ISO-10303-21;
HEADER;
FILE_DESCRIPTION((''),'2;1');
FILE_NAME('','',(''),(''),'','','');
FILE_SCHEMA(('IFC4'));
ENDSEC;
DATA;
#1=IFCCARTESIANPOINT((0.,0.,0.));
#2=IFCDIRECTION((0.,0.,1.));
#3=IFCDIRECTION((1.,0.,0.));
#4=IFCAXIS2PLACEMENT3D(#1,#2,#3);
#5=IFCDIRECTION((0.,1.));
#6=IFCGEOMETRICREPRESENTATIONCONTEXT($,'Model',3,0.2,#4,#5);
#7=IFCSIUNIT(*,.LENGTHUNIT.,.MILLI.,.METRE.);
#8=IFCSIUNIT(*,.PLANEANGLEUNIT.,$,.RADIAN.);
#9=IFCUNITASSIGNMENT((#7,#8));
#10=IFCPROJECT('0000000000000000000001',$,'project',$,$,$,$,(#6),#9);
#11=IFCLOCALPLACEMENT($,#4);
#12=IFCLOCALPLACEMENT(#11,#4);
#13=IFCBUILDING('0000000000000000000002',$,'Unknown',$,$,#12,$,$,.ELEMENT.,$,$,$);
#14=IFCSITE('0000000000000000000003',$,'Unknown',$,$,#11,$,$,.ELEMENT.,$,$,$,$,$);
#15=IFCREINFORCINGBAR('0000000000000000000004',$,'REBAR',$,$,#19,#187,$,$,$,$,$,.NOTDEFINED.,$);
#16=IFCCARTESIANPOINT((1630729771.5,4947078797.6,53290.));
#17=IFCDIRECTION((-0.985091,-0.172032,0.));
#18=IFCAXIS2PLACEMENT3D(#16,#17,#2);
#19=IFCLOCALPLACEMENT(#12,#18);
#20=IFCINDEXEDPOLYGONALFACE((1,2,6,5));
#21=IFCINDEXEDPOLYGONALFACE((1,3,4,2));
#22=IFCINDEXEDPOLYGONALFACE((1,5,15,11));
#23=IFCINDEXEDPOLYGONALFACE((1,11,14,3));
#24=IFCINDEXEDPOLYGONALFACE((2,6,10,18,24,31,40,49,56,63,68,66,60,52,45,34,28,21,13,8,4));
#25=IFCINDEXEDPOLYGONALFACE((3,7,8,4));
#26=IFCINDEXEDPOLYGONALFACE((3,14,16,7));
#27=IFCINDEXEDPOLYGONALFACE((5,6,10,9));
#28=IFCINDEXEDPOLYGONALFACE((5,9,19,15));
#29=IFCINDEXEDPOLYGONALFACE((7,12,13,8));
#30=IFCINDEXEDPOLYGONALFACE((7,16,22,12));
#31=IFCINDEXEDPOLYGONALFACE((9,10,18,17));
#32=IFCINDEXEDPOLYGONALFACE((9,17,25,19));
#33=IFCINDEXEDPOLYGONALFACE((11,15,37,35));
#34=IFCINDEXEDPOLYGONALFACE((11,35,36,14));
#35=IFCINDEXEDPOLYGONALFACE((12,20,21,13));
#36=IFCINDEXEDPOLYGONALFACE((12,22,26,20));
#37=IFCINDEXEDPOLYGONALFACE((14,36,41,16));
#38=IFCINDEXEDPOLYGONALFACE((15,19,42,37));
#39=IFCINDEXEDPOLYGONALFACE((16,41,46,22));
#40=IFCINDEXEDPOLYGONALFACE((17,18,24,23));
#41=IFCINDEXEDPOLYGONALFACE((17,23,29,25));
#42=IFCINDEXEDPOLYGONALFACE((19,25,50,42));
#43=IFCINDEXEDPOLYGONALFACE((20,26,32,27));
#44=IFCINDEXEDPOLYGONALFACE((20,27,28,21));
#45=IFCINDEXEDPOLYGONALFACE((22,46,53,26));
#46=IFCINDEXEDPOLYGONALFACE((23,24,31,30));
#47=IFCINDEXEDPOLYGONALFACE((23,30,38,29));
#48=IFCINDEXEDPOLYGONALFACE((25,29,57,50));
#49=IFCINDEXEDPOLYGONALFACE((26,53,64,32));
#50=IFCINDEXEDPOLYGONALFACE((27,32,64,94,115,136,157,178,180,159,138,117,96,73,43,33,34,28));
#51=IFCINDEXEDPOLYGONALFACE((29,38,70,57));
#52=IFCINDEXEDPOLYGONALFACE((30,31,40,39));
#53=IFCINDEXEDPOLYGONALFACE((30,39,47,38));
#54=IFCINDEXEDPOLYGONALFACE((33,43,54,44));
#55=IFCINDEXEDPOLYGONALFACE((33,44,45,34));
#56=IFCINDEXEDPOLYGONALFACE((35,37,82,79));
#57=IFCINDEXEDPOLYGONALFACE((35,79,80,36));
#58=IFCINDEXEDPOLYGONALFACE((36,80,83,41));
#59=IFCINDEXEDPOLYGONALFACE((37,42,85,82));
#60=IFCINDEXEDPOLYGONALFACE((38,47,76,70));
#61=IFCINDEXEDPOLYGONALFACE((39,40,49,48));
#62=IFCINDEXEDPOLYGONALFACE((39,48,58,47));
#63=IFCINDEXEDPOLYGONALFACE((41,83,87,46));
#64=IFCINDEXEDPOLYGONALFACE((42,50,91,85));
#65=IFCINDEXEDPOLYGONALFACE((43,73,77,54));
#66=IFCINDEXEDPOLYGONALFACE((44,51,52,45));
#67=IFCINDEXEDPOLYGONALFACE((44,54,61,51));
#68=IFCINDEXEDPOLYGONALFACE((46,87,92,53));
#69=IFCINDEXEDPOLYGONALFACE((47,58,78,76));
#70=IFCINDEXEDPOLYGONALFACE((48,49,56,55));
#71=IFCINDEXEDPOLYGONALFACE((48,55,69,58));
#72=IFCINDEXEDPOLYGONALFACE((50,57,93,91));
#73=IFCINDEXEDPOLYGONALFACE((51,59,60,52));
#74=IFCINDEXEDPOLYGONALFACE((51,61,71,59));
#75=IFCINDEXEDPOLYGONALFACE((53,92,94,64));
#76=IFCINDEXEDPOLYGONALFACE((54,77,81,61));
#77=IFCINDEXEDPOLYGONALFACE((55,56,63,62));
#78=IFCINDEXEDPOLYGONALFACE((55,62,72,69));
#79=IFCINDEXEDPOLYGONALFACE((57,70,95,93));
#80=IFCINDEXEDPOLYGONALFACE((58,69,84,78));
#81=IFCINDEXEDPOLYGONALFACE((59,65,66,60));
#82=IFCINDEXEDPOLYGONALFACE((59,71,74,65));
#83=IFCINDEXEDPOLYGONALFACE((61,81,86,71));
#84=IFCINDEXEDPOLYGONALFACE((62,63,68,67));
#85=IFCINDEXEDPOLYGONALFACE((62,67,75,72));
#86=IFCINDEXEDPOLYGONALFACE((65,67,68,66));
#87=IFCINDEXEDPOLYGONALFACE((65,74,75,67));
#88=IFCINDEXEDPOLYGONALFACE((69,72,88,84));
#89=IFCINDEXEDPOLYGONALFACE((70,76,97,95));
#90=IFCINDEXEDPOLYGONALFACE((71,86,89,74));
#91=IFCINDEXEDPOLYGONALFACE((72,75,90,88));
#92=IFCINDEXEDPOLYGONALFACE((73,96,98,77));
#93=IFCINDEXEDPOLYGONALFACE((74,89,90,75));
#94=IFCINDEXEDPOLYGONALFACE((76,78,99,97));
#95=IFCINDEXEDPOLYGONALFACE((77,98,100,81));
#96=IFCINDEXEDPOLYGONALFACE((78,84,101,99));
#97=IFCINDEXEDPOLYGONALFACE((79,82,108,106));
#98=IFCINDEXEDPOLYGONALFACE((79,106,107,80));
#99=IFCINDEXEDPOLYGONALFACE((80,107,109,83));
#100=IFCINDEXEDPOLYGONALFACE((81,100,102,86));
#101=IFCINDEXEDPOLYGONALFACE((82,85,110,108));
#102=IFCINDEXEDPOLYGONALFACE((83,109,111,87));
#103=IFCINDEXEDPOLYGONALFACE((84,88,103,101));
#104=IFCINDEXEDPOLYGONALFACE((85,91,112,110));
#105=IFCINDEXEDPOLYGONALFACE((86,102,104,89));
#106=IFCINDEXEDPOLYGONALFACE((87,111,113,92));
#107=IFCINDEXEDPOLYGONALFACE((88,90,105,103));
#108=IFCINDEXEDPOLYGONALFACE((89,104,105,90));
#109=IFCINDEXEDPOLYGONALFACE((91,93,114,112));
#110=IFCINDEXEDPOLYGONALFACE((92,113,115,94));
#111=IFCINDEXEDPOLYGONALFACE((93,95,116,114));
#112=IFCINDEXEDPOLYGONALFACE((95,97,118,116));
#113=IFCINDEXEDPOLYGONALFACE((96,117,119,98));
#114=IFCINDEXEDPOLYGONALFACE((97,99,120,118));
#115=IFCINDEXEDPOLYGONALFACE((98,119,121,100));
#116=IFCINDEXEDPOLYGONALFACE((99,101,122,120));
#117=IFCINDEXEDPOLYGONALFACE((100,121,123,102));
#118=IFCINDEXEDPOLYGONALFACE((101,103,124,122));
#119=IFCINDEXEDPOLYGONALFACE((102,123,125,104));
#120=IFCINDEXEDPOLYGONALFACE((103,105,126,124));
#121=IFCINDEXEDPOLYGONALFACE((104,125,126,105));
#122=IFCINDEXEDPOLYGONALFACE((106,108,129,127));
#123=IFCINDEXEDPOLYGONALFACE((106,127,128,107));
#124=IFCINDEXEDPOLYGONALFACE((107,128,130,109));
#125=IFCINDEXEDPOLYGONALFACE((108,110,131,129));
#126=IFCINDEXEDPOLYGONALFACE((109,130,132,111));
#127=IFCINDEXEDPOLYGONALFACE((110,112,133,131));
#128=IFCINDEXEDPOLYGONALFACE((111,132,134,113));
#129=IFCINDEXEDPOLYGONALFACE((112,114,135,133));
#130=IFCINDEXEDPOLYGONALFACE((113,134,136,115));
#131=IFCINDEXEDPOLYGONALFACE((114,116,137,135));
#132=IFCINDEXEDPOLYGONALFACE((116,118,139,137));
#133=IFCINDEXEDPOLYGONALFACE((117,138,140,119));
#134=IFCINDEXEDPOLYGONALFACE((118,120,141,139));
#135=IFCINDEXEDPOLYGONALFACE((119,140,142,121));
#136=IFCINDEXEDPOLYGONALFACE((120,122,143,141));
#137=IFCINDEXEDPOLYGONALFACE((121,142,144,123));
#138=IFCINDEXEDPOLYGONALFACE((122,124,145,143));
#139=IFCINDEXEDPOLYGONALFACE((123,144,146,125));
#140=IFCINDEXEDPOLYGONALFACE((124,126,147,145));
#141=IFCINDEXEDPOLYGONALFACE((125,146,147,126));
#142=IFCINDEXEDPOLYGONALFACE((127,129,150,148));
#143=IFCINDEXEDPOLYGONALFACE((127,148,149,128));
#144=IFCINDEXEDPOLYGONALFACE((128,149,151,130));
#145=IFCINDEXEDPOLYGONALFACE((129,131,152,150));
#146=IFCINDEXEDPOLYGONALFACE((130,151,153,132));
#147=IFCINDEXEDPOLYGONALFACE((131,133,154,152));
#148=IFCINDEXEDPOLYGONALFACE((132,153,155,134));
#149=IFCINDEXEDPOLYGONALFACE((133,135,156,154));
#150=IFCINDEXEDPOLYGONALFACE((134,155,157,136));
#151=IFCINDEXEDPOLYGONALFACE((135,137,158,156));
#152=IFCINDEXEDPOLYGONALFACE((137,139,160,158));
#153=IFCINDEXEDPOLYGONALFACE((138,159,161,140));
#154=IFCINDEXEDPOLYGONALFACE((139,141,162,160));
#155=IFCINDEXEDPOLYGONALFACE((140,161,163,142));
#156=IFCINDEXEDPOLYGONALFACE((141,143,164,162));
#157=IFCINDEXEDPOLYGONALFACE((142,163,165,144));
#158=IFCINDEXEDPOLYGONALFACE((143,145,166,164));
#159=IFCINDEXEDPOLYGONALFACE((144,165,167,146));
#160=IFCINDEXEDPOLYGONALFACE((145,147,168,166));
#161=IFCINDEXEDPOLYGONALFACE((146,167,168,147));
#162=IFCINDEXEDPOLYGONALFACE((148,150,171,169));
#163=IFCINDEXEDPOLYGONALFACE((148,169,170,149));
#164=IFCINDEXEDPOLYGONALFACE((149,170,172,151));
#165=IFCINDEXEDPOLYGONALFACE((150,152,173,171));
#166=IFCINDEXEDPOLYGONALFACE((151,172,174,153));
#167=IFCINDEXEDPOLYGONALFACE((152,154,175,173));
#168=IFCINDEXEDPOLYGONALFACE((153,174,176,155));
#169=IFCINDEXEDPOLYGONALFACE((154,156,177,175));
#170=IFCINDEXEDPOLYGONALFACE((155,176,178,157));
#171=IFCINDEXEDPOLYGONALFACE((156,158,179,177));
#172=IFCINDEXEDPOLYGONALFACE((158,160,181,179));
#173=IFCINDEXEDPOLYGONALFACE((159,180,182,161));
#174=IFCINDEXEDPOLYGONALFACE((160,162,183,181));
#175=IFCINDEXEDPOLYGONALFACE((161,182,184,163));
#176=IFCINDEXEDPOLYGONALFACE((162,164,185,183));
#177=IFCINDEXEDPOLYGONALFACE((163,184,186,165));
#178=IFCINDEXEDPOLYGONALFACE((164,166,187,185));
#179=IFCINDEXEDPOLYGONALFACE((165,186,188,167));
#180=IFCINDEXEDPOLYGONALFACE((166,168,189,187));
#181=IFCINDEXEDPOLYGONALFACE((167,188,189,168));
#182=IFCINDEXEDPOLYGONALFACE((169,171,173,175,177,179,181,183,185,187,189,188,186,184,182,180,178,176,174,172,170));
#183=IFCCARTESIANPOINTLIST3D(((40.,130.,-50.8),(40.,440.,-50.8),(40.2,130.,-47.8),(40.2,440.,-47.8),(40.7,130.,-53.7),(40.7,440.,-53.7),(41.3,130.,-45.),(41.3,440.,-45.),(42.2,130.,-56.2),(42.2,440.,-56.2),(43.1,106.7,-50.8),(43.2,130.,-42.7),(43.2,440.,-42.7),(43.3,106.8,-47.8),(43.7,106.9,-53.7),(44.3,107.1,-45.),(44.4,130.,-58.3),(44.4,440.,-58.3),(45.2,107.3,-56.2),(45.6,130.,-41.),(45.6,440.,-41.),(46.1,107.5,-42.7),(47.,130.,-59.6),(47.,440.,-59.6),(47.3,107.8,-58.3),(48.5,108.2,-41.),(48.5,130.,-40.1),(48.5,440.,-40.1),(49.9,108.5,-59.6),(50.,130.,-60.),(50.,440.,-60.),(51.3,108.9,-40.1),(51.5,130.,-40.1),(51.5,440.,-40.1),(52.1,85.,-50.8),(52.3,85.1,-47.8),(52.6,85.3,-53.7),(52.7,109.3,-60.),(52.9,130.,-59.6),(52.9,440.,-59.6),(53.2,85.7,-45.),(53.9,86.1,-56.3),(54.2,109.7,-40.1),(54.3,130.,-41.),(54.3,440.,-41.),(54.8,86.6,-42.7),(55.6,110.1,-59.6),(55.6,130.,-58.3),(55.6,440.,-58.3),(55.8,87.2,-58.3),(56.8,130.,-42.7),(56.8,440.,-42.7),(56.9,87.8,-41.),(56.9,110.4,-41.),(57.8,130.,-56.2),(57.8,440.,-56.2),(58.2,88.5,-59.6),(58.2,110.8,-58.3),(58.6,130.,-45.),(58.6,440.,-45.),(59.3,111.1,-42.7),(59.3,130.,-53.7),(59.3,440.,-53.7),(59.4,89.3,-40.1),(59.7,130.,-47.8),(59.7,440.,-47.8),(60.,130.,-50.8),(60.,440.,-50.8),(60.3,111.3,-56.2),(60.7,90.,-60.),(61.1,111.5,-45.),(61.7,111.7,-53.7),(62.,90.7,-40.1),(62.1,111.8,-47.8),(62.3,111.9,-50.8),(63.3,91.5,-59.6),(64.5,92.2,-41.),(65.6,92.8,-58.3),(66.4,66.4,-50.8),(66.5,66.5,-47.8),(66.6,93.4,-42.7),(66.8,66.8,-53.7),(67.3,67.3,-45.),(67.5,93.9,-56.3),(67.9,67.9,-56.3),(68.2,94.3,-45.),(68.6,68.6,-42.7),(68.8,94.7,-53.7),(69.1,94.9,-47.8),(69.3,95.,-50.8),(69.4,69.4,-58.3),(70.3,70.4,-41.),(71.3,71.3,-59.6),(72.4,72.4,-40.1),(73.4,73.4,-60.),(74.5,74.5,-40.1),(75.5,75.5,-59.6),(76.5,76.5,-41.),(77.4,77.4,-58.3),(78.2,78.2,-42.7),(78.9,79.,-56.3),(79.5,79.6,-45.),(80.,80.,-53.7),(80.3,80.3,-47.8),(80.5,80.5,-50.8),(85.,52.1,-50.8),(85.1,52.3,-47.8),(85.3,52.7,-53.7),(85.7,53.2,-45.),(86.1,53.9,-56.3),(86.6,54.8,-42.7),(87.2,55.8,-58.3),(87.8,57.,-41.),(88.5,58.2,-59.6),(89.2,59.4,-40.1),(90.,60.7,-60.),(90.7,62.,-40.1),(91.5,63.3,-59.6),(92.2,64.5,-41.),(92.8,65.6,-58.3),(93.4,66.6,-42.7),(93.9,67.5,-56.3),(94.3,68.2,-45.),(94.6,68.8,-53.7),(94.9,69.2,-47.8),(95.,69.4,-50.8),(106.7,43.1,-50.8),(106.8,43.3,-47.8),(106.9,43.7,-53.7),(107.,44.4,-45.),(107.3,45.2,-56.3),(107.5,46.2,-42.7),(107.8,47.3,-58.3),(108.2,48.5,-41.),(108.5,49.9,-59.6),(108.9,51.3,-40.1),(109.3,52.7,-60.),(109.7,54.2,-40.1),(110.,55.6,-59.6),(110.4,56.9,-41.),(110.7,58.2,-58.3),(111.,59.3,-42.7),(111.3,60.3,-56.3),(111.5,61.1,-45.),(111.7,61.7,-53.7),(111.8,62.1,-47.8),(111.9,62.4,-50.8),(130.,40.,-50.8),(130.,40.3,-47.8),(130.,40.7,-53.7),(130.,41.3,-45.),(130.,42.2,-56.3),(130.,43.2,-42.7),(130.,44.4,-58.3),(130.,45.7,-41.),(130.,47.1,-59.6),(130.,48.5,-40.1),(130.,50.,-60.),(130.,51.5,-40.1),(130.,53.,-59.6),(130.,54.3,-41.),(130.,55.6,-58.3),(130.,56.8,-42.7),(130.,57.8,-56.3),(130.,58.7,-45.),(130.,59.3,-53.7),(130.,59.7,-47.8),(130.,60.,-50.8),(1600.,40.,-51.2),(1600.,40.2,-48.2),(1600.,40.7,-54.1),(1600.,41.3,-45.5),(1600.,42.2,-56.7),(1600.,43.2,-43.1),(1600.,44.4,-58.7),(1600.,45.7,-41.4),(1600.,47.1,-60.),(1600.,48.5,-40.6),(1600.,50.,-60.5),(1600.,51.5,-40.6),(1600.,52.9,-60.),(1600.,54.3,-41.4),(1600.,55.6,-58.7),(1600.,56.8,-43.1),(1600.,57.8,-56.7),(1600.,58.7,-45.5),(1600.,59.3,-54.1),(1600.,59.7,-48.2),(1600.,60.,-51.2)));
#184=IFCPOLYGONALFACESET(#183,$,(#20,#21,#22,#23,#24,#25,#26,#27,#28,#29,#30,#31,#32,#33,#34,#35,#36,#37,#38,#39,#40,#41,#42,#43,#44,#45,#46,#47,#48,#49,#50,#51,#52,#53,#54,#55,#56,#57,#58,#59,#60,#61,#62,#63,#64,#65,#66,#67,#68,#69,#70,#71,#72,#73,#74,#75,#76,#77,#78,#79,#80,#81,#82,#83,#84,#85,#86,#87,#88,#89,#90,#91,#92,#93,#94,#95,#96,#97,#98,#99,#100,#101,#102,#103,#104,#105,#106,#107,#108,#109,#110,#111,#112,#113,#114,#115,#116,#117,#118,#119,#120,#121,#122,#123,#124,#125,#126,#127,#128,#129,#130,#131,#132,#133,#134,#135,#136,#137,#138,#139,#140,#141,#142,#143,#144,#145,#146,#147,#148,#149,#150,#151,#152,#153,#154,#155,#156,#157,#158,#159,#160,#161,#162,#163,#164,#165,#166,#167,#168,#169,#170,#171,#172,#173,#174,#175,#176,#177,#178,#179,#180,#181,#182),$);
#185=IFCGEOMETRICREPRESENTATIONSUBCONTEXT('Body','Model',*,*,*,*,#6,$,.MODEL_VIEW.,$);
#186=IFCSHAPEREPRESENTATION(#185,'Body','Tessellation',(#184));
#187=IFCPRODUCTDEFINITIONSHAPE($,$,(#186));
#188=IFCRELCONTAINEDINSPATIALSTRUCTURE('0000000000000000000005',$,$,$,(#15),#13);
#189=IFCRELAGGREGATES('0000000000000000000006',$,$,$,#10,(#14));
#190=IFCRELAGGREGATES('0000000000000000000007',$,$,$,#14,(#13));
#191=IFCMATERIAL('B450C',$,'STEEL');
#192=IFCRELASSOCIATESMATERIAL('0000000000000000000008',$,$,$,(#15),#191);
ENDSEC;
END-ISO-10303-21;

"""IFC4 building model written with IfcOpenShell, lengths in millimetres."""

from ifc_helpers import new_model, entity, si_unit, direction, frame, origin_with_axes, place, context, subcontext, project, spatial, material, element, save


model = new_model("IFC4")

# Units and contexts
model_context = context("Model", 3, precision=0.2, world=origin_with_axes(), true_north=direction((0.0, 1.0)))
body_context = subcontext(model_context, "Body", "Model", "MODEL_VIEW")
ifc_project = project(units=[si_unit("LENGTHUNIT", "METRE", prefix="MILLI"), si_unit("PLANEANGLEUNIT", "RADIAN")], contexts=[model_context])

# Site, building
site_placement = place(None, origin_with_axes())
site = spatial("IfcSite", under=ifc_project, at=site_placement, Name="Unknown", CompositionType="ELEMENT")
building_placement = place(site_placement, origin_with_axes())
building = spatial("IfcBuilding", under=site, at=building_placement, Name="Unknown", CompositionType="ELEMENT")

# Reinforcing bar
ifc_material = material(Name="B450C", Category="STEEL")
reinforcing_bar_1_placement = place(building_placement, frame((1630729771.5, 4947078797.6, 53290.0), z_axis=(-0.985091, -0.172032, 0.0), x_axis=(0.0, 0.0, 1.0)))
element("IfcReinforcingBar", 1, at=reinforcing_bar_1_placement, inside=building, material=ifc_material, Name="REBAR", PredefinedType="NOTDEFINED", context=body_context, shape_type="AdvancedSweptSolid", body=[
    entity("IfcSweptDiskSolid", entity("IfcIndexedPolyCurve", entity("IfcCartesianPointList3D", [[50.0, 440.0, -50.0], [50.0, 130.0, -50.0], [73.4, 73.4, -50.0], [130.0, 50.0, -50.0], [1600.0, 50.0, -50.5]]), [entity("IfcLineIndex", [1, 2]), entity("IfcArcIndex", [2, 3, 4]), entity("IfcLineIndex", [4, 5])]), 10.0),
])

save(model, "model.ifc")
